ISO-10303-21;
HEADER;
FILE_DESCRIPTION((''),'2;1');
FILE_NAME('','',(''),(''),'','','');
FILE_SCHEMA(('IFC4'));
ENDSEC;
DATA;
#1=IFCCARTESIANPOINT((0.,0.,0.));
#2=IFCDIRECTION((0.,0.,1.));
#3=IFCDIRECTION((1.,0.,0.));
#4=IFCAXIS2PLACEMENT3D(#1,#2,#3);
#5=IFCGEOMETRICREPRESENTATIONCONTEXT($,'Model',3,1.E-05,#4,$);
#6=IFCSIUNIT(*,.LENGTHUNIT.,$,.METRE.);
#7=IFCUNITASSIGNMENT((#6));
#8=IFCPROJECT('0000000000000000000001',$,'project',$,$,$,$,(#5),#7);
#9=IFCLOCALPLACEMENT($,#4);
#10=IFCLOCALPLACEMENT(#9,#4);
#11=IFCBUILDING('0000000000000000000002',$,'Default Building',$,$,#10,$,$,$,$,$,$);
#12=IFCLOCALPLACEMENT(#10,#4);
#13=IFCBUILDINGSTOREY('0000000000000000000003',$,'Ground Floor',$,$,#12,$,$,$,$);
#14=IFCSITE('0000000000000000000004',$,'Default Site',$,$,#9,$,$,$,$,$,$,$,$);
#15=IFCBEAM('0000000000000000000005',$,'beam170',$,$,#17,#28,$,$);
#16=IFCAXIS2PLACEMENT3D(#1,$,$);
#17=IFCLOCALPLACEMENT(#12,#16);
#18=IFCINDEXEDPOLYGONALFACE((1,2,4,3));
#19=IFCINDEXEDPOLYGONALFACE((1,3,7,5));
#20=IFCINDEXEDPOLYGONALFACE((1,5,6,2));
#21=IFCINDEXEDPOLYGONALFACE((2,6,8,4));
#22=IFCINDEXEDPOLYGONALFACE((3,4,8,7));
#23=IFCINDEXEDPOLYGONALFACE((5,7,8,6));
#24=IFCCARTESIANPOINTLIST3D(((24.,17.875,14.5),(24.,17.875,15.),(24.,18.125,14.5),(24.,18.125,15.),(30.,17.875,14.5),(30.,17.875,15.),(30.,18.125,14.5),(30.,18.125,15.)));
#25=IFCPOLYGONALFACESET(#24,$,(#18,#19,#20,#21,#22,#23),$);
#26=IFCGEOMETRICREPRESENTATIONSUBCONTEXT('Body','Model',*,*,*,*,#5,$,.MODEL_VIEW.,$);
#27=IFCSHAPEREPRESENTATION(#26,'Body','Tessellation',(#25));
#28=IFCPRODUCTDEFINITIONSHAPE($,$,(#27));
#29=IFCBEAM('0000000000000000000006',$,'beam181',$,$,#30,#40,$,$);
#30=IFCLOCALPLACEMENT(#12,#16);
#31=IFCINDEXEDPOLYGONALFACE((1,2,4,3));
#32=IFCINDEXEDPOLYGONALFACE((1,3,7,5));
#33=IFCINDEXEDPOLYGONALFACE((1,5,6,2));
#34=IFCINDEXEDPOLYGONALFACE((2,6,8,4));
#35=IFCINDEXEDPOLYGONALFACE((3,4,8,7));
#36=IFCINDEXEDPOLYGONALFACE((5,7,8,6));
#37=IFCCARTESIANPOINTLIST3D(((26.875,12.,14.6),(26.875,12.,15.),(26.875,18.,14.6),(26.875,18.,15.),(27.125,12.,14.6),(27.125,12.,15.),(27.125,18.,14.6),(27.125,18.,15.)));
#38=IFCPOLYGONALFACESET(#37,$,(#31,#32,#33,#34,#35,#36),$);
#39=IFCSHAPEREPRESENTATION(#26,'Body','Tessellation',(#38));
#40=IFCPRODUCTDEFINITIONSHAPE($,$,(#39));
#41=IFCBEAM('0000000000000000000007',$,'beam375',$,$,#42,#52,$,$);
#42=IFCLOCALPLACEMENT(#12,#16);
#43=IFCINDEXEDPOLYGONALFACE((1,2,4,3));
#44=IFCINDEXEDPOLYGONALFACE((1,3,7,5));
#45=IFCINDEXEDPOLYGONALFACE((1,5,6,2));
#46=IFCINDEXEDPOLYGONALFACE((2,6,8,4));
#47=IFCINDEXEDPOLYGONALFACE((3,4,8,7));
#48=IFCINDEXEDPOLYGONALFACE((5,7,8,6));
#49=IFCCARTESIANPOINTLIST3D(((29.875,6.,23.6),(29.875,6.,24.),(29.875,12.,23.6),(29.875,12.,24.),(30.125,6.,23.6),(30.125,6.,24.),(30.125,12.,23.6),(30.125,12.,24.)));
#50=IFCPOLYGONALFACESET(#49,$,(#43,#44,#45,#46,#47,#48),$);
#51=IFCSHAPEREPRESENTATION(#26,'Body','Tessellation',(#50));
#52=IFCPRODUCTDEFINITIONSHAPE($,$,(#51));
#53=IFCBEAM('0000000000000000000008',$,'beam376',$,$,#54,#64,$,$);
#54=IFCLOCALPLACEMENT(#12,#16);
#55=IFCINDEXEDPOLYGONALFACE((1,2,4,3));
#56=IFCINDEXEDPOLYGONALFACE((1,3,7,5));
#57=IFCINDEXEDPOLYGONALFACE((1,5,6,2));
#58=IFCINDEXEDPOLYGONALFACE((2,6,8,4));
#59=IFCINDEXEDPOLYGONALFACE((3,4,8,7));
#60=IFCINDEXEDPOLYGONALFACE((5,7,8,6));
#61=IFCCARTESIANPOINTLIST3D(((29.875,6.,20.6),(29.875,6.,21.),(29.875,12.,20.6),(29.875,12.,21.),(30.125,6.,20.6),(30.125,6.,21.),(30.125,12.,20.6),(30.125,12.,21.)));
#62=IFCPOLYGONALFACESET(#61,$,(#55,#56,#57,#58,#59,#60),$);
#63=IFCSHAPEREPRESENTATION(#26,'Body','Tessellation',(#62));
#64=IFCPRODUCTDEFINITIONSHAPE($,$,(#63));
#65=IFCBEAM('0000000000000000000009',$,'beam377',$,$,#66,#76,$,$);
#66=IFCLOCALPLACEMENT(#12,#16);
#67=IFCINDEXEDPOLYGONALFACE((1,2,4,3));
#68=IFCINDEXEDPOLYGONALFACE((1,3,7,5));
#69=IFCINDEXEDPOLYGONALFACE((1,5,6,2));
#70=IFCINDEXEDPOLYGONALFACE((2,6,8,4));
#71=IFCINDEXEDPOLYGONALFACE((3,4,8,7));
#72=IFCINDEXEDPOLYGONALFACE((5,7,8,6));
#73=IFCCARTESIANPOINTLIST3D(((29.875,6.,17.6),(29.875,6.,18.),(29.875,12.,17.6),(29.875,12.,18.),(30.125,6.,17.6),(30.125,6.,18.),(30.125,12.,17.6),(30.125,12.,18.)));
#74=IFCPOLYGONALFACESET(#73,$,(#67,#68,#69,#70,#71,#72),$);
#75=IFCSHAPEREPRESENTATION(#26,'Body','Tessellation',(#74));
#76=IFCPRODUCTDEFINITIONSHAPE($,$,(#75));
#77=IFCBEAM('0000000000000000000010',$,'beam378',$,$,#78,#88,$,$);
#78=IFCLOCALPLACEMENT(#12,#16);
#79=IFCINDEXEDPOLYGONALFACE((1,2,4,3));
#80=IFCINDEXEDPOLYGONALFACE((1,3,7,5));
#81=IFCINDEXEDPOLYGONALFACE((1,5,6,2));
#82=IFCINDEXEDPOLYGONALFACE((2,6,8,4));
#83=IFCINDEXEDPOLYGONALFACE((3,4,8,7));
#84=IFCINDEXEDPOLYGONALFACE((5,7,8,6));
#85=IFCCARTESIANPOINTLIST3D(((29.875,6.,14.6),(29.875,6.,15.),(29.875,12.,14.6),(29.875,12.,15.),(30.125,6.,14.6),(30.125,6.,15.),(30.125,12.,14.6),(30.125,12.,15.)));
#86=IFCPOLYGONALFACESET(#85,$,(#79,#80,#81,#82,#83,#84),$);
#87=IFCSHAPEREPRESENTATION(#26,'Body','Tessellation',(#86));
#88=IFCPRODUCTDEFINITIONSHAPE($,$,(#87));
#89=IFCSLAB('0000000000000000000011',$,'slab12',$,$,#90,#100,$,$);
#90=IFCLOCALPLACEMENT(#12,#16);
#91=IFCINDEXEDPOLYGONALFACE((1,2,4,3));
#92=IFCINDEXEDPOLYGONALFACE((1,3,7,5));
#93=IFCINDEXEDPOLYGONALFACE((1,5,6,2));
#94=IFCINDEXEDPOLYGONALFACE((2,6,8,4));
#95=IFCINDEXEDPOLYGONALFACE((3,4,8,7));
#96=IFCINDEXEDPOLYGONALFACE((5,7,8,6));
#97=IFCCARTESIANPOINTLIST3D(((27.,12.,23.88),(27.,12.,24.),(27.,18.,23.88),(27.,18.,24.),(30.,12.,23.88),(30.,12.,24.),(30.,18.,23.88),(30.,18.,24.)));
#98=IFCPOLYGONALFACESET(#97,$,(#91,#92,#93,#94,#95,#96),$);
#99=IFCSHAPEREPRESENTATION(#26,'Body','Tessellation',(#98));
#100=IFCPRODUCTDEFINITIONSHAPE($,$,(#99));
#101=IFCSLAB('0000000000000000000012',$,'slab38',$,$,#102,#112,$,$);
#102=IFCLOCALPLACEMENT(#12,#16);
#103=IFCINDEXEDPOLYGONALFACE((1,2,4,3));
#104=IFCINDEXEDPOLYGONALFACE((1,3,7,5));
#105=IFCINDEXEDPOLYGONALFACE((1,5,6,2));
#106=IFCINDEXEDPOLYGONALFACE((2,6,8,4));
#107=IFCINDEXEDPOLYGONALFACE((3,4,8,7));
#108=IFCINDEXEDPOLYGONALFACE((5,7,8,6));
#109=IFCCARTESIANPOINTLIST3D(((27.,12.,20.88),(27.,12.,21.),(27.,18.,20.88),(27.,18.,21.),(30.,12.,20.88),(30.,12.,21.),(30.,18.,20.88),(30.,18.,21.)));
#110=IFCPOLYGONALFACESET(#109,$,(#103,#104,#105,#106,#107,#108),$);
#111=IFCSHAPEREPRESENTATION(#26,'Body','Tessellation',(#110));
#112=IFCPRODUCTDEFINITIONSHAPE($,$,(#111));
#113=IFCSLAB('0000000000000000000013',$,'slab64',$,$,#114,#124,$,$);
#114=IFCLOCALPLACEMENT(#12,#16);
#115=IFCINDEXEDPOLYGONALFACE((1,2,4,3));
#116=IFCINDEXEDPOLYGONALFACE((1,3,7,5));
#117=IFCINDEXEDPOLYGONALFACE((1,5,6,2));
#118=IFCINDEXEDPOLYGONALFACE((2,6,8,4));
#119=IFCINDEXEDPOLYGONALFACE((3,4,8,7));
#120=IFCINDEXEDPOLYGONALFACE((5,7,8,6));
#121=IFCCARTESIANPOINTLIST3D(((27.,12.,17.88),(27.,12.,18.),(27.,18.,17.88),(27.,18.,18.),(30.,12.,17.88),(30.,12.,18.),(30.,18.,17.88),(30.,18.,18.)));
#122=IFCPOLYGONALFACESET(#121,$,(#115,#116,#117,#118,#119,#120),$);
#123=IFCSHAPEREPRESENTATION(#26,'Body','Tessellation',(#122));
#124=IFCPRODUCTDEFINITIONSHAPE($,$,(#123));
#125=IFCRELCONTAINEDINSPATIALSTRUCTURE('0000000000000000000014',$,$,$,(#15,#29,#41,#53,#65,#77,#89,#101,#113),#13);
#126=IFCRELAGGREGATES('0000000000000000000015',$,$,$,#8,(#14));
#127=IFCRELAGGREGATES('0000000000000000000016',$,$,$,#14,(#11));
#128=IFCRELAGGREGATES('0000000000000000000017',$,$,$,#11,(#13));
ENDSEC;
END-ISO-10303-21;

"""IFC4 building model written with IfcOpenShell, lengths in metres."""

from ifc_helpers import new_model, si_unit, frame, origin_with_axes, place, context, subcontext, project, spatial, indexed_curve, outline, extrude, element, save


model = new_model("IFC4")

# Units and contexts
model_context = context("Model", 3, precision=1e-05, world=origin_with_axes())
body_context = subcontext(model_context, "Body", "Model", "MODEL_VIEW")
ifc_project = project(units=[si_unit("LENGTHUNIT", "METRE")], contexts=[model_context])

# Site, building, storey
site_placement = place(None, origin_with_axes())
site = spatial("IfcSite", under=ifc_project, at=site_placement, Name="Default Site")
building_placement = place(site_placement, origin_with_axes())
building = spatial("IfcBuilding", under=site, at=building_placement, Name="Default Building")
storey_placement = place(building_placement, origin_with_axes())
storey = spatial("IfcBuildingStorey", under=building, at=storey_placement, Name="Ground Floor")

# Beams
beam_1_placement = place(storey_placement, frame((24.0, 17.875, 14.5), z_axis=(0.0, 0.0, 1.0), x_axis=(1.0, 0.0, 0.0)))
element("IfcBeam", 1, at=beam_1_placement, inside=storey, Name="beam170", context=body_context, shape_type="SweptSolid", body=[
    extrude(outline(indexed_curve([(0.0, 0.0), (0.0, 0.25), (6.0, 0.25), (6.0, 0.0), (0.0, 0.0)], self_intersect=False)), origin_with_axes(), (0.0, 0.0, 1.0), 0.5),
])
for number, where, z_axis, x_axis, name in (
    (2, (26.875, 18.0, 14.6), (0.0, 0.0, 1.0), (0.0, -1.0, 0.0), "beam181"),
    (3, (29.875, 12.0, 23.6), (0.0, 0.0, 1.0), (0.0, -1.0, 0.0), "beam375"),
    (4, (29.875, 12.0, 20.6), (0.0, 0.0, 1.0), (0.0, -1.0, 0.0), "beam376"),
    (5, (29.875, 12.0, 17.6), (0.0, 0.0, 1.0), (0.0, -1.0, 0.0), "beam377"),
    (6, (29.875, 12.0, 14.6), (0.0, 0.0, 1.0), (0.0, -1.0, 0.0), "beam378"),
):
    element("IfcBeam", number, at=place(storey_placement, frame(where, z_axis=z_axis, x_axis=x_axis)), inside=storey, Name=name, context=body_context, shape_type="SweptSolid", body=[
        extrude(outline(indexed_curve([(0.0, 0.0), (0.0, 0.25), (6.0, 0.25), (6.0, 0.0), (0.0, 0.0)], self_intersect=False)), origin_with_axes(), (0.0, 0.0, 1.0), 0.4),
    ])

# Slabs
for number, where, z_axis, x_axis, name in (
    (7, (27.0, 12.0, 23.88), (0.0, 0.0, 1.0), (1.0, 0.0, 0.0), "slab12"),
    (8, (27.0, 12.0, 20.88), (0.0, 0.0, 1.0), (1.0, 0.0, 0.0), "slab38"),
    (9, (27.0, 12.0, 17.88), (0.0, 0.0, 1.0), (1.0, 0.0, 0.0), "slab64"),
):
    element("IfcSlab", number, at=place(storey_placement, frame(where, z_axis=z_axis, x_axis=x_axis)), inside=storey, Name=name, context=body_context, shape_type="SweptSolid", body=[
        extrude(outline(indexed_curve([(0.0, 0.0), (0.0, 6.0), (3.0, 6.0), (3.0, 0.0), (0.0, 0.0)], self_intersect=False)), origin_with_axes(), (0.0, 0.0, 1.0), 0.12),
    ])

save(model, "model.ifc")
